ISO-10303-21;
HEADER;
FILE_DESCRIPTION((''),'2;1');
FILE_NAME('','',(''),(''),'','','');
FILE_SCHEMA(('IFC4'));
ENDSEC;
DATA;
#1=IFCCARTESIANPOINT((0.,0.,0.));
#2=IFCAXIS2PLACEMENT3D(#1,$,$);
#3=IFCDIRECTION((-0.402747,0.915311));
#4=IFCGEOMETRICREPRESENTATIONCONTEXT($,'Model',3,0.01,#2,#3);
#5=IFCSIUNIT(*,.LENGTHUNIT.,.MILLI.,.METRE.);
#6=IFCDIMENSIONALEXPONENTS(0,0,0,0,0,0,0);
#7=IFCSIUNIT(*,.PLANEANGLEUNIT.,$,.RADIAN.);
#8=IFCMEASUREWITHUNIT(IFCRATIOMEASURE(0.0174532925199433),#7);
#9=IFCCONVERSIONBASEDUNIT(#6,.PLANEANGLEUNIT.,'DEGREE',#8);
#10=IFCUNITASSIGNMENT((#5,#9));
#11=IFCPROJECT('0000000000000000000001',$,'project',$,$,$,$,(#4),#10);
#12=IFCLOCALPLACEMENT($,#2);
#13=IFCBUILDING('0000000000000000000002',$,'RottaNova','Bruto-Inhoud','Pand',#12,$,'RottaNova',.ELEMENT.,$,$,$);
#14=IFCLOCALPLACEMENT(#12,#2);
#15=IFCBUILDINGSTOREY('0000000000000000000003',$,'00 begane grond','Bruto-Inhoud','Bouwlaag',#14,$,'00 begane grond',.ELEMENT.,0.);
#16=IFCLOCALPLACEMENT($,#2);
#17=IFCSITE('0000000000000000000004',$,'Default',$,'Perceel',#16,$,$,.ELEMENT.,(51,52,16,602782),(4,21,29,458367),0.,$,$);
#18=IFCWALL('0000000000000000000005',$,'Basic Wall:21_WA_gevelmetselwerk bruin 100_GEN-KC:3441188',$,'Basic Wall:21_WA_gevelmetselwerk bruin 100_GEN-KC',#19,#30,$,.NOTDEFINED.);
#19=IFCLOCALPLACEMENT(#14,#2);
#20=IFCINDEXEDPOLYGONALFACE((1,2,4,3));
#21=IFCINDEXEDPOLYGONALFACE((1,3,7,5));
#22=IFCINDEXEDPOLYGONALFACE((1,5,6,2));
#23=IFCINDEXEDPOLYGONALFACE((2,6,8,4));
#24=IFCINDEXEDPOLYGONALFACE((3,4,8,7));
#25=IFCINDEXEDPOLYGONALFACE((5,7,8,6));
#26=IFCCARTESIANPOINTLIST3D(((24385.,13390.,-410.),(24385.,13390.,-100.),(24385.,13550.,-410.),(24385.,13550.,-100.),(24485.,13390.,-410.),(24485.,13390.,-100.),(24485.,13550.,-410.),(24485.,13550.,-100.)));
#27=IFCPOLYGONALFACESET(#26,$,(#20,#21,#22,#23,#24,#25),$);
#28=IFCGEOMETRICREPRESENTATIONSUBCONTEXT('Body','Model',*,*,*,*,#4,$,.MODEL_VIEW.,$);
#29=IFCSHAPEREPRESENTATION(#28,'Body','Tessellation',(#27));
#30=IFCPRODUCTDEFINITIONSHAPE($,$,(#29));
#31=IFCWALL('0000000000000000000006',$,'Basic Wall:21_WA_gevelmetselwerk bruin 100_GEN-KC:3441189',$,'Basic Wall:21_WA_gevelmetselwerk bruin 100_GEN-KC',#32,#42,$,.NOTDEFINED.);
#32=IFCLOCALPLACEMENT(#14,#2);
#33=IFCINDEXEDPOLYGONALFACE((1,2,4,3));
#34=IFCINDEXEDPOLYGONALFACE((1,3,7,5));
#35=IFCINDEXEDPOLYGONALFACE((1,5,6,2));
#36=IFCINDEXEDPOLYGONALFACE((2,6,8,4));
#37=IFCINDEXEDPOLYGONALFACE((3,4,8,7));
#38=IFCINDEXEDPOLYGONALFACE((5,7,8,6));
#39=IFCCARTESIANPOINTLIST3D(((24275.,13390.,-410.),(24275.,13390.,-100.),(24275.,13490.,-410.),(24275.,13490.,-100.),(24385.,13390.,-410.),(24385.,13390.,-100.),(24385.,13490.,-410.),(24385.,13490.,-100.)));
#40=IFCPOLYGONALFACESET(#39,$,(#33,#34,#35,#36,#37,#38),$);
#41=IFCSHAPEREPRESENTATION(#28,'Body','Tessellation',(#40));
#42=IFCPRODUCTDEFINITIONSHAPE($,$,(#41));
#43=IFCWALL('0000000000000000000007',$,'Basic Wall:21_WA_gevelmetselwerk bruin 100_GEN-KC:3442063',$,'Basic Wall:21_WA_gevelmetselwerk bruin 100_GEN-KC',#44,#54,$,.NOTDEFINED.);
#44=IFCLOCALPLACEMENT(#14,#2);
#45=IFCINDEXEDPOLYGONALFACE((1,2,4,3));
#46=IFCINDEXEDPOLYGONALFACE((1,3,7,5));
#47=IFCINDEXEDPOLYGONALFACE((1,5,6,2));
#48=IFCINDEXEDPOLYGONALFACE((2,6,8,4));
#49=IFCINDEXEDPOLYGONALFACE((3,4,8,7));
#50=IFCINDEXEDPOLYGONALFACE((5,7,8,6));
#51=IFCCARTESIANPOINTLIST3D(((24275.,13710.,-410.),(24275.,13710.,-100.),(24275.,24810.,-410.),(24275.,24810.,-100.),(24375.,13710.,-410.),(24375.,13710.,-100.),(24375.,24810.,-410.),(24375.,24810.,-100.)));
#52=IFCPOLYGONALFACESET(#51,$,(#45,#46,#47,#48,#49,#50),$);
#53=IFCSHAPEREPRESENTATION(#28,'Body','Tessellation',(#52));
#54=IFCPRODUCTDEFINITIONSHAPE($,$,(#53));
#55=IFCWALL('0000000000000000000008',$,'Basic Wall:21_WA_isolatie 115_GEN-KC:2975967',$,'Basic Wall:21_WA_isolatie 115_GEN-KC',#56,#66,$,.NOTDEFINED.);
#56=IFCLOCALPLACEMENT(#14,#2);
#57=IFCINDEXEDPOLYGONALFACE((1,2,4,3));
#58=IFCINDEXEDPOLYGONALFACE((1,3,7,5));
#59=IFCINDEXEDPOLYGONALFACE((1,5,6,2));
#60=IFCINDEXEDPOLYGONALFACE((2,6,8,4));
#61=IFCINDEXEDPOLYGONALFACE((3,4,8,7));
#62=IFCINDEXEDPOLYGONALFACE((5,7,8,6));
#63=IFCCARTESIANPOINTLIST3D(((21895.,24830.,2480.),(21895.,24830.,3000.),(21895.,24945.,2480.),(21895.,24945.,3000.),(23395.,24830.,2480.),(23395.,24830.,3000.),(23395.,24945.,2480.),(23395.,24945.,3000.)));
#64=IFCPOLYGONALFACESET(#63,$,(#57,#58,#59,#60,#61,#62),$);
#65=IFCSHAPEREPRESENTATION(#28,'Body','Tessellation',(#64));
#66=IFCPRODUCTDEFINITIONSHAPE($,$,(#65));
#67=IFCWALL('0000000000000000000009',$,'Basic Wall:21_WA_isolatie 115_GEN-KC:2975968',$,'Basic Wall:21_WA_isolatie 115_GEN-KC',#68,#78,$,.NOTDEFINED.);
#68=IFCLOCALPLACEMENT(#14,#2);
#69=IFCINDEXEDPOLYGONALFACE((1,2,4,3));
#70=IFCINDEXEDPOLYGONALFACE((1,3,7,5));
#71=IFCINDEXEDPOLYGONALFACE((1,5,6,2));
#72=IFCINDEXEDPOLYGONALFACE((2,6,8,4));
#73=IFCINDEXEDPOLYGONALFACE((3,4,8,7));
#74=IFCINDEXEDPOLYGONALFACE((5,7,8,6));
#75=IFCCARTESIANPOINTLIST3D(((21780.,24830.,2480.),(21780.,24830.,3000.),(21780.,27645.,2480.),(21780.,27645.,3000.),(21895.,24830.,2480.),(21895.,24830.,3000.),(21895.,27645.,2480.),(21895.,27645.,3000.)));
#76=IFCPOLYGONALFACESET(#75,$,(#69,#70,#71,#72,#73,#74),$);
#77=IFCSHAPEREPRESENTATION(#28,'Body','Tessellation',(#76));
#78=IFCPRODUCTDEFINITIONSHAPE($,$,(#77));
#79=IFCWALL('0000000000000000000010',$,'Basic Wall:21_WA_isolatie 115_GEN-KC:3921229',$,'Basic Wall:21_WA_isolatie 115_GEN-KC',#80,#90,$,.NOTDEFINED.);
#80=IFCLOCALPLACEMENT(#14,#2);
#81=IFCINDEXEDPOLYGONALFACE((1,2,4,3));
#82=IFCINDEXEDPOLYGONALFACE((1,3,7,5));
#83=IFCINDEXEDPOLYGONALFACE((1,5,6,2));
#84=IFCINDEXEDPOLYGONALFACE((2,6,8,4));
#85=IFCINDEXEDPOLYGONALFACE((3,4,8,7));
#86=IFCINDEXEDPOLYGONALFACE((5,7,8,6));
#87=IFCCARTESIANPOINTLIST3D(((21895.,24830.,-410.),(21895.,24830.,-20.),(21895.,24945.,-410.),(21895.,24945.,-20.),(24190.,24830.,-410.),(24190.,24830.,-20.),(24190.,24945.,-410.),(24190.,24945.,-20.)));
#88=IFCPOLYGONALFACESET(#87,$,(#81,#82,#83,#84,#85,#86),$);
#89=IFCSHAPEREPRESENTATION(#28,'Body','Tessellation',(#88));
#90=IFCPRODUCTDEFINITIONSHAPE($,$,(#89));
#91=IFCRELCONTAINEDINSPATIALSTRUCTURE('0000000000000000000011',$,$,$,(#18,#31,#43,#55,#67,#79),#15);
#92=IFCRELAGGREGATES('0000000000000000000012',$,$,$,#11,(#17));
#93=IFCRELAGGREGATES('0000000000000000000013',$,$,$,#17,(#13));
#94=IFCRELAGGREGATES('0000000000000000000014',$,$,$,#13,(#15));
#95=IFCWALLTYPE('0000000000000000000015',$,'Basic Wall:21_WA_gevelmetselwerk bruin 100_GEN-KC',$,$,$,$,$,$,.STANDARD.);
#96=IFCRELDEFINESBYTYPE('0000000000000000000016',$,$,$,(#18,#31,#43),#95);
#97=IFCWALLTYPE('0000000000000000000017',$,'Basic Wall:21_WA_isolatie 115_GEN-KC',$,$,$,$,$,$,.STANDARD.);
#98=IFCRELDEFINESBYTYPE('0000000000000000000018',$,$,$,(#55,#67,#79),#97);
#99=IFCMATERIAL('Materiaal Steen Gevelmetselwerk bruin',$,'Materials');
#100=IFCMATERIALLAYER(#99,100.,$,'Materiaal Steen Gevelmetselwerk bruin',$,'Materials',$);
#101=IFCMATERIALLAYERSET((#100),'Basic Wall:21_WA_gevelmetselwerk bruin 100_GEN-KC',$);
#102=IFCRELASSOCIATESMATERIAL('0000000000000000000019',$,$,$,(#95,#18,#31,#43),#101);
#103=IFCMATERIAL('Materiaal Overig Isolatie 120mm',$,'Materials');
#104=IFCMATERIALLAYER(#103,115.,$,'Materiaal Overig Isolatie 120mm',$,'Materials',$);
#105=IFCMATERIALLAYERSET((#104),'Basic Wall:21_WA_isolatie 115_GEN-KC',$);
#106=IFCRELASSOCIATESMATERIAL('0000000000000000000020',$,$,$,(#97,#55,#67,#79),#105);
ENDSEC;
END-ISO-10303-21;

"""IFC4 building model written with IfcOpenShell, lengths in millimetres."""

from ifc_helpers import new_model, entity, si_unit, converted_unit, direction, frame, frame_2d, origin, place, context, subcontext, project, spatial, rectangle, extrude, material, layer, layer_set, type_object, element, save


model = new_model("IFC4")

# Units and contexts
model_context = context("Model", 3, precision=0.01, world=origin(), true_north=direction((-0.402747, 0.915311)))
body_context = subcontext(model_context, "Body", "Model", "MODEL_VIEW")
ifc_project = project(units=[si_unit("LENGTHUNIT", "METRE", prefix="MILLI"), converted_unit("PLANEANGLEUNIT", "DEGREE", entity("IfcRatioMeasure", 0.0174532925199433), si_unit("PLANEANGLEUNIT", "RADIAN"), dimensions=[0, 0, 0, 0, 0, 0, 0])], contexts=[model_context])

# Site, building, storey
site_placement = place(None, origin())
site = spatial("IfcSite", under=ifc_project, at=site_placement, Name="Default", ObjectType="Perceel", CompositionType="ELEMENT", RefLatitude=(51, 52, 16, 602782), RefLongitude=(4, 21, 29, 458367), RefElevation=0.0)
building_placement = place(None, origin())
building = spatial("IfcBuilding", under=site, at=building_placement, Name="RottaNova", Description="Bruto-Inhoud", ObjectType="Pand", LongName="RottaNova", CompositionType="ELEMENT")
storey_placement = place(building_placement, origin())
storey = spatial("IfcBuildingStorey", under=building, at=storey_placement, Name="00 begane grond", Description="Bruto-Inhoud", ObjectType="Bouwlaag", LongName="00 begane grond", CompositionType="ELEMENT", Elevation=0.0)

# Walls
ifc_material_1 = material(Name="Materiaal Steen Gevelmetselwerk bruin", Category="Materials")
ifc_layer_1 = layer(ifc_material_1, 100.0, Name="Materiaal Steen Gevelmetselwerk bruin", Category="Materials")
ifc_layer_set_1 = layer_set([ifc_layer_1], Name="Basic Wall:21_WA_gevelmetselwerk bruin 100_GEN-KC")
wall_type_1 = type_object("IfcWallType", Name="Basic Wall:21_WA_gevelmetselwerk bruin 100_GEN-KC", PredefinedType="STANDARD", material=ifc_layer_set_1)
wall_1_placement = place(storey_placement, frame((24435.0, 13550.0, -410.0), z_axis=(0.0, 0.0, 1.0), x_axis=(0.0, -1.0, 0.0)))
element("IfcWall", 1, at=wall_1_placement, inside=storey, type_object=wall_type_1, material=ifc_layer_set_1, Name="Basic Wall:21_WA_gevelmetselwerk bruin 100_GEN-KC:3441188", ObjectType="Basic Wall:21_WA_gevelmetselwerk bruin 100_GEN-KC", PredefinedType="NOTDEFINED", context=body_context, shape_type="SweptSolid", body=[
    extrude(rectangle(XDim=160.0, YDim=100.0, at=frame_2d((80.0, 0.0), x_axis=(-1.0, 0.0))), origin(), (0.0, 0.0, 1.0), 310.0),
])
wall_2_placement = place(storey_placement, frame((24385.0, 13440.0, -410.0), z_axis=(0.0, 0.0, 1.0), x_axis=(-1.0, 0.0, 0.0)))
element("IfcWall", 2, at=wall_2_placement, inside=storey, type_object=wall_type_1, material=ifc_layer_set_1, Name="Basic Wall:21_WA_gevelmetselwerk bruin 100_GEN-KC:3441189", ObjectType="Basic Wall:21_WA_gevelmetselwerk bruin 100_GEN-KC", PredefinedType="NOTDEFINED", context=body_context, shape_type="SweptSolid", body=[
    extrude(rectangle(XDim=110.0, YDim=100.0, at=frame_2d((55.0, 0.0), x_axis=(-1.0, 0.0))), origin(), (0.0, 0.0, 1.0), 310.0),
])
wall_3_placement = place(storey_placement, frame((24325.0, 13710.0, -410.0), z_axis=(0.0, 0.0, 1.0), x_axis=(0.0, 1.0, 0.0)))
element("IfcWall", 3, at=wall_3_placement, inside=storey, type_object=wall_type_1, material=ifc_layer_set_1, Name="Basic Wall:21_WA_gevelmetselwerk bruin 100_GEN-KC:3442063", ObjectType="Basic Wall:21_WA_gevelmetselwerk bruin 100_GEN-KC", PredefinedType="NOTDEFINED", context=body_context, shape_type="SweptSolid", body=[
    extrude(rectangle(XDim=11100.0, YDim=100.0, at=frame_2d((5550.0, 0.0), x_axis=(-1.0, 0.0))), origin(), (0.0, 0.0, 1.0), 310.0),
])
ifc_material_2 = material(Name="Materiaal Overig Isolatie 120mm", Category="Materials")
ifc_layer_2 = layer(ifc_material_2, 115.0, Name="Materiaal Overig Isolatie 120mm", Category="Materials")
ifc_layer_set_2 = layer_set([ifc_layer_2], Name="Basic Wall:21_WA_isolatie 115_GEN-KC")
wall_type_2 = type_object("IfcWallType", Name="Basic Wall:21_WA_isolatie 115_GEN-KC", PredefinedType="STANDARD", material=ifc_layer_set_2)
wall_4_placement = place(storey_placement, frame((23395.0, 24887.5, 2480.0), z_axis=(0.0, 0.0, 1.0), x_axis=(-1.0, 0.0, 0.0)))
element("IfcWall", 4, at=wall_4_placement, inside=storey, type_object=wall_type_2, material=ifc_layer_set_2, Name="Basic Wall:21_WA_isolatie 115_GEN-KC:2975967", ObjectType="Basic Wall:21_WA_isolatie 115_GEN-KC", PredefinedType="NOTDEFINED", context=body_context, shape_type="SweptSolid", body=[
    extrude(rectangle(XDim=1500.0, YDim=115.0, at=frame_2d((750.0, 0.0), x_axis=(1.0, 0.0))), origin(), (0.0, 0.0, 1.0), 520.0),
])
wall_5_placement = place(storey_placement, frame((21837.5, 24830.0, 2480.0), z_axis=(0.0, 0.0, 1.0), x_axis=(0.0, 1.0, 0.0)))
element("IfcWall", 5, at=wall_5_placement, inside=storey, type_object=wall_type_2, material=ifc_layer_set_2, Name="Basic Wall:21_WA_isolatie 115_GEN-KC:2975968", ObjectType="Basic Wall:21_WA_isolatie 115_GEN-KC", PredefinedType="NOTDEFINED", context=body_context, shape_type="SweptSolid", body=[
    extrude(rectangle(XDim=2815.0, YDim=115.0, at=frame_2d((1407.5, 0.0), x_axis=(-1.0, 0.0))), origin(), (0.0, 0.0, 1.0), 520.0),
])
wall_6_placement = place(storey_placement, frame((21895.0, 24887.5, -410.0)))
element("IfcWall", 6, at=wall_6_placement, inside=storey, type_object=wall_type_2, material=ifc_layer_set_2, Name="Basic Wall:21_WA_isolatie 115_GEN-KC:3921229", ObjectType="Basic Wall:21_WA_isolatie 115_GEN-KC", PredefinedType="NOTDEFINED", context=body_context, shape_type="SweptSolid", body=[
    extrude(rectangle(XDim=2295.0, YDim=115.0, at=frame_2d((1147.5, 0.0), x_axis=(-1.0, 0.0))), origin(), (0.0, 0.0, 1.0), 390.0),
])

save(model, "model.ifc")
